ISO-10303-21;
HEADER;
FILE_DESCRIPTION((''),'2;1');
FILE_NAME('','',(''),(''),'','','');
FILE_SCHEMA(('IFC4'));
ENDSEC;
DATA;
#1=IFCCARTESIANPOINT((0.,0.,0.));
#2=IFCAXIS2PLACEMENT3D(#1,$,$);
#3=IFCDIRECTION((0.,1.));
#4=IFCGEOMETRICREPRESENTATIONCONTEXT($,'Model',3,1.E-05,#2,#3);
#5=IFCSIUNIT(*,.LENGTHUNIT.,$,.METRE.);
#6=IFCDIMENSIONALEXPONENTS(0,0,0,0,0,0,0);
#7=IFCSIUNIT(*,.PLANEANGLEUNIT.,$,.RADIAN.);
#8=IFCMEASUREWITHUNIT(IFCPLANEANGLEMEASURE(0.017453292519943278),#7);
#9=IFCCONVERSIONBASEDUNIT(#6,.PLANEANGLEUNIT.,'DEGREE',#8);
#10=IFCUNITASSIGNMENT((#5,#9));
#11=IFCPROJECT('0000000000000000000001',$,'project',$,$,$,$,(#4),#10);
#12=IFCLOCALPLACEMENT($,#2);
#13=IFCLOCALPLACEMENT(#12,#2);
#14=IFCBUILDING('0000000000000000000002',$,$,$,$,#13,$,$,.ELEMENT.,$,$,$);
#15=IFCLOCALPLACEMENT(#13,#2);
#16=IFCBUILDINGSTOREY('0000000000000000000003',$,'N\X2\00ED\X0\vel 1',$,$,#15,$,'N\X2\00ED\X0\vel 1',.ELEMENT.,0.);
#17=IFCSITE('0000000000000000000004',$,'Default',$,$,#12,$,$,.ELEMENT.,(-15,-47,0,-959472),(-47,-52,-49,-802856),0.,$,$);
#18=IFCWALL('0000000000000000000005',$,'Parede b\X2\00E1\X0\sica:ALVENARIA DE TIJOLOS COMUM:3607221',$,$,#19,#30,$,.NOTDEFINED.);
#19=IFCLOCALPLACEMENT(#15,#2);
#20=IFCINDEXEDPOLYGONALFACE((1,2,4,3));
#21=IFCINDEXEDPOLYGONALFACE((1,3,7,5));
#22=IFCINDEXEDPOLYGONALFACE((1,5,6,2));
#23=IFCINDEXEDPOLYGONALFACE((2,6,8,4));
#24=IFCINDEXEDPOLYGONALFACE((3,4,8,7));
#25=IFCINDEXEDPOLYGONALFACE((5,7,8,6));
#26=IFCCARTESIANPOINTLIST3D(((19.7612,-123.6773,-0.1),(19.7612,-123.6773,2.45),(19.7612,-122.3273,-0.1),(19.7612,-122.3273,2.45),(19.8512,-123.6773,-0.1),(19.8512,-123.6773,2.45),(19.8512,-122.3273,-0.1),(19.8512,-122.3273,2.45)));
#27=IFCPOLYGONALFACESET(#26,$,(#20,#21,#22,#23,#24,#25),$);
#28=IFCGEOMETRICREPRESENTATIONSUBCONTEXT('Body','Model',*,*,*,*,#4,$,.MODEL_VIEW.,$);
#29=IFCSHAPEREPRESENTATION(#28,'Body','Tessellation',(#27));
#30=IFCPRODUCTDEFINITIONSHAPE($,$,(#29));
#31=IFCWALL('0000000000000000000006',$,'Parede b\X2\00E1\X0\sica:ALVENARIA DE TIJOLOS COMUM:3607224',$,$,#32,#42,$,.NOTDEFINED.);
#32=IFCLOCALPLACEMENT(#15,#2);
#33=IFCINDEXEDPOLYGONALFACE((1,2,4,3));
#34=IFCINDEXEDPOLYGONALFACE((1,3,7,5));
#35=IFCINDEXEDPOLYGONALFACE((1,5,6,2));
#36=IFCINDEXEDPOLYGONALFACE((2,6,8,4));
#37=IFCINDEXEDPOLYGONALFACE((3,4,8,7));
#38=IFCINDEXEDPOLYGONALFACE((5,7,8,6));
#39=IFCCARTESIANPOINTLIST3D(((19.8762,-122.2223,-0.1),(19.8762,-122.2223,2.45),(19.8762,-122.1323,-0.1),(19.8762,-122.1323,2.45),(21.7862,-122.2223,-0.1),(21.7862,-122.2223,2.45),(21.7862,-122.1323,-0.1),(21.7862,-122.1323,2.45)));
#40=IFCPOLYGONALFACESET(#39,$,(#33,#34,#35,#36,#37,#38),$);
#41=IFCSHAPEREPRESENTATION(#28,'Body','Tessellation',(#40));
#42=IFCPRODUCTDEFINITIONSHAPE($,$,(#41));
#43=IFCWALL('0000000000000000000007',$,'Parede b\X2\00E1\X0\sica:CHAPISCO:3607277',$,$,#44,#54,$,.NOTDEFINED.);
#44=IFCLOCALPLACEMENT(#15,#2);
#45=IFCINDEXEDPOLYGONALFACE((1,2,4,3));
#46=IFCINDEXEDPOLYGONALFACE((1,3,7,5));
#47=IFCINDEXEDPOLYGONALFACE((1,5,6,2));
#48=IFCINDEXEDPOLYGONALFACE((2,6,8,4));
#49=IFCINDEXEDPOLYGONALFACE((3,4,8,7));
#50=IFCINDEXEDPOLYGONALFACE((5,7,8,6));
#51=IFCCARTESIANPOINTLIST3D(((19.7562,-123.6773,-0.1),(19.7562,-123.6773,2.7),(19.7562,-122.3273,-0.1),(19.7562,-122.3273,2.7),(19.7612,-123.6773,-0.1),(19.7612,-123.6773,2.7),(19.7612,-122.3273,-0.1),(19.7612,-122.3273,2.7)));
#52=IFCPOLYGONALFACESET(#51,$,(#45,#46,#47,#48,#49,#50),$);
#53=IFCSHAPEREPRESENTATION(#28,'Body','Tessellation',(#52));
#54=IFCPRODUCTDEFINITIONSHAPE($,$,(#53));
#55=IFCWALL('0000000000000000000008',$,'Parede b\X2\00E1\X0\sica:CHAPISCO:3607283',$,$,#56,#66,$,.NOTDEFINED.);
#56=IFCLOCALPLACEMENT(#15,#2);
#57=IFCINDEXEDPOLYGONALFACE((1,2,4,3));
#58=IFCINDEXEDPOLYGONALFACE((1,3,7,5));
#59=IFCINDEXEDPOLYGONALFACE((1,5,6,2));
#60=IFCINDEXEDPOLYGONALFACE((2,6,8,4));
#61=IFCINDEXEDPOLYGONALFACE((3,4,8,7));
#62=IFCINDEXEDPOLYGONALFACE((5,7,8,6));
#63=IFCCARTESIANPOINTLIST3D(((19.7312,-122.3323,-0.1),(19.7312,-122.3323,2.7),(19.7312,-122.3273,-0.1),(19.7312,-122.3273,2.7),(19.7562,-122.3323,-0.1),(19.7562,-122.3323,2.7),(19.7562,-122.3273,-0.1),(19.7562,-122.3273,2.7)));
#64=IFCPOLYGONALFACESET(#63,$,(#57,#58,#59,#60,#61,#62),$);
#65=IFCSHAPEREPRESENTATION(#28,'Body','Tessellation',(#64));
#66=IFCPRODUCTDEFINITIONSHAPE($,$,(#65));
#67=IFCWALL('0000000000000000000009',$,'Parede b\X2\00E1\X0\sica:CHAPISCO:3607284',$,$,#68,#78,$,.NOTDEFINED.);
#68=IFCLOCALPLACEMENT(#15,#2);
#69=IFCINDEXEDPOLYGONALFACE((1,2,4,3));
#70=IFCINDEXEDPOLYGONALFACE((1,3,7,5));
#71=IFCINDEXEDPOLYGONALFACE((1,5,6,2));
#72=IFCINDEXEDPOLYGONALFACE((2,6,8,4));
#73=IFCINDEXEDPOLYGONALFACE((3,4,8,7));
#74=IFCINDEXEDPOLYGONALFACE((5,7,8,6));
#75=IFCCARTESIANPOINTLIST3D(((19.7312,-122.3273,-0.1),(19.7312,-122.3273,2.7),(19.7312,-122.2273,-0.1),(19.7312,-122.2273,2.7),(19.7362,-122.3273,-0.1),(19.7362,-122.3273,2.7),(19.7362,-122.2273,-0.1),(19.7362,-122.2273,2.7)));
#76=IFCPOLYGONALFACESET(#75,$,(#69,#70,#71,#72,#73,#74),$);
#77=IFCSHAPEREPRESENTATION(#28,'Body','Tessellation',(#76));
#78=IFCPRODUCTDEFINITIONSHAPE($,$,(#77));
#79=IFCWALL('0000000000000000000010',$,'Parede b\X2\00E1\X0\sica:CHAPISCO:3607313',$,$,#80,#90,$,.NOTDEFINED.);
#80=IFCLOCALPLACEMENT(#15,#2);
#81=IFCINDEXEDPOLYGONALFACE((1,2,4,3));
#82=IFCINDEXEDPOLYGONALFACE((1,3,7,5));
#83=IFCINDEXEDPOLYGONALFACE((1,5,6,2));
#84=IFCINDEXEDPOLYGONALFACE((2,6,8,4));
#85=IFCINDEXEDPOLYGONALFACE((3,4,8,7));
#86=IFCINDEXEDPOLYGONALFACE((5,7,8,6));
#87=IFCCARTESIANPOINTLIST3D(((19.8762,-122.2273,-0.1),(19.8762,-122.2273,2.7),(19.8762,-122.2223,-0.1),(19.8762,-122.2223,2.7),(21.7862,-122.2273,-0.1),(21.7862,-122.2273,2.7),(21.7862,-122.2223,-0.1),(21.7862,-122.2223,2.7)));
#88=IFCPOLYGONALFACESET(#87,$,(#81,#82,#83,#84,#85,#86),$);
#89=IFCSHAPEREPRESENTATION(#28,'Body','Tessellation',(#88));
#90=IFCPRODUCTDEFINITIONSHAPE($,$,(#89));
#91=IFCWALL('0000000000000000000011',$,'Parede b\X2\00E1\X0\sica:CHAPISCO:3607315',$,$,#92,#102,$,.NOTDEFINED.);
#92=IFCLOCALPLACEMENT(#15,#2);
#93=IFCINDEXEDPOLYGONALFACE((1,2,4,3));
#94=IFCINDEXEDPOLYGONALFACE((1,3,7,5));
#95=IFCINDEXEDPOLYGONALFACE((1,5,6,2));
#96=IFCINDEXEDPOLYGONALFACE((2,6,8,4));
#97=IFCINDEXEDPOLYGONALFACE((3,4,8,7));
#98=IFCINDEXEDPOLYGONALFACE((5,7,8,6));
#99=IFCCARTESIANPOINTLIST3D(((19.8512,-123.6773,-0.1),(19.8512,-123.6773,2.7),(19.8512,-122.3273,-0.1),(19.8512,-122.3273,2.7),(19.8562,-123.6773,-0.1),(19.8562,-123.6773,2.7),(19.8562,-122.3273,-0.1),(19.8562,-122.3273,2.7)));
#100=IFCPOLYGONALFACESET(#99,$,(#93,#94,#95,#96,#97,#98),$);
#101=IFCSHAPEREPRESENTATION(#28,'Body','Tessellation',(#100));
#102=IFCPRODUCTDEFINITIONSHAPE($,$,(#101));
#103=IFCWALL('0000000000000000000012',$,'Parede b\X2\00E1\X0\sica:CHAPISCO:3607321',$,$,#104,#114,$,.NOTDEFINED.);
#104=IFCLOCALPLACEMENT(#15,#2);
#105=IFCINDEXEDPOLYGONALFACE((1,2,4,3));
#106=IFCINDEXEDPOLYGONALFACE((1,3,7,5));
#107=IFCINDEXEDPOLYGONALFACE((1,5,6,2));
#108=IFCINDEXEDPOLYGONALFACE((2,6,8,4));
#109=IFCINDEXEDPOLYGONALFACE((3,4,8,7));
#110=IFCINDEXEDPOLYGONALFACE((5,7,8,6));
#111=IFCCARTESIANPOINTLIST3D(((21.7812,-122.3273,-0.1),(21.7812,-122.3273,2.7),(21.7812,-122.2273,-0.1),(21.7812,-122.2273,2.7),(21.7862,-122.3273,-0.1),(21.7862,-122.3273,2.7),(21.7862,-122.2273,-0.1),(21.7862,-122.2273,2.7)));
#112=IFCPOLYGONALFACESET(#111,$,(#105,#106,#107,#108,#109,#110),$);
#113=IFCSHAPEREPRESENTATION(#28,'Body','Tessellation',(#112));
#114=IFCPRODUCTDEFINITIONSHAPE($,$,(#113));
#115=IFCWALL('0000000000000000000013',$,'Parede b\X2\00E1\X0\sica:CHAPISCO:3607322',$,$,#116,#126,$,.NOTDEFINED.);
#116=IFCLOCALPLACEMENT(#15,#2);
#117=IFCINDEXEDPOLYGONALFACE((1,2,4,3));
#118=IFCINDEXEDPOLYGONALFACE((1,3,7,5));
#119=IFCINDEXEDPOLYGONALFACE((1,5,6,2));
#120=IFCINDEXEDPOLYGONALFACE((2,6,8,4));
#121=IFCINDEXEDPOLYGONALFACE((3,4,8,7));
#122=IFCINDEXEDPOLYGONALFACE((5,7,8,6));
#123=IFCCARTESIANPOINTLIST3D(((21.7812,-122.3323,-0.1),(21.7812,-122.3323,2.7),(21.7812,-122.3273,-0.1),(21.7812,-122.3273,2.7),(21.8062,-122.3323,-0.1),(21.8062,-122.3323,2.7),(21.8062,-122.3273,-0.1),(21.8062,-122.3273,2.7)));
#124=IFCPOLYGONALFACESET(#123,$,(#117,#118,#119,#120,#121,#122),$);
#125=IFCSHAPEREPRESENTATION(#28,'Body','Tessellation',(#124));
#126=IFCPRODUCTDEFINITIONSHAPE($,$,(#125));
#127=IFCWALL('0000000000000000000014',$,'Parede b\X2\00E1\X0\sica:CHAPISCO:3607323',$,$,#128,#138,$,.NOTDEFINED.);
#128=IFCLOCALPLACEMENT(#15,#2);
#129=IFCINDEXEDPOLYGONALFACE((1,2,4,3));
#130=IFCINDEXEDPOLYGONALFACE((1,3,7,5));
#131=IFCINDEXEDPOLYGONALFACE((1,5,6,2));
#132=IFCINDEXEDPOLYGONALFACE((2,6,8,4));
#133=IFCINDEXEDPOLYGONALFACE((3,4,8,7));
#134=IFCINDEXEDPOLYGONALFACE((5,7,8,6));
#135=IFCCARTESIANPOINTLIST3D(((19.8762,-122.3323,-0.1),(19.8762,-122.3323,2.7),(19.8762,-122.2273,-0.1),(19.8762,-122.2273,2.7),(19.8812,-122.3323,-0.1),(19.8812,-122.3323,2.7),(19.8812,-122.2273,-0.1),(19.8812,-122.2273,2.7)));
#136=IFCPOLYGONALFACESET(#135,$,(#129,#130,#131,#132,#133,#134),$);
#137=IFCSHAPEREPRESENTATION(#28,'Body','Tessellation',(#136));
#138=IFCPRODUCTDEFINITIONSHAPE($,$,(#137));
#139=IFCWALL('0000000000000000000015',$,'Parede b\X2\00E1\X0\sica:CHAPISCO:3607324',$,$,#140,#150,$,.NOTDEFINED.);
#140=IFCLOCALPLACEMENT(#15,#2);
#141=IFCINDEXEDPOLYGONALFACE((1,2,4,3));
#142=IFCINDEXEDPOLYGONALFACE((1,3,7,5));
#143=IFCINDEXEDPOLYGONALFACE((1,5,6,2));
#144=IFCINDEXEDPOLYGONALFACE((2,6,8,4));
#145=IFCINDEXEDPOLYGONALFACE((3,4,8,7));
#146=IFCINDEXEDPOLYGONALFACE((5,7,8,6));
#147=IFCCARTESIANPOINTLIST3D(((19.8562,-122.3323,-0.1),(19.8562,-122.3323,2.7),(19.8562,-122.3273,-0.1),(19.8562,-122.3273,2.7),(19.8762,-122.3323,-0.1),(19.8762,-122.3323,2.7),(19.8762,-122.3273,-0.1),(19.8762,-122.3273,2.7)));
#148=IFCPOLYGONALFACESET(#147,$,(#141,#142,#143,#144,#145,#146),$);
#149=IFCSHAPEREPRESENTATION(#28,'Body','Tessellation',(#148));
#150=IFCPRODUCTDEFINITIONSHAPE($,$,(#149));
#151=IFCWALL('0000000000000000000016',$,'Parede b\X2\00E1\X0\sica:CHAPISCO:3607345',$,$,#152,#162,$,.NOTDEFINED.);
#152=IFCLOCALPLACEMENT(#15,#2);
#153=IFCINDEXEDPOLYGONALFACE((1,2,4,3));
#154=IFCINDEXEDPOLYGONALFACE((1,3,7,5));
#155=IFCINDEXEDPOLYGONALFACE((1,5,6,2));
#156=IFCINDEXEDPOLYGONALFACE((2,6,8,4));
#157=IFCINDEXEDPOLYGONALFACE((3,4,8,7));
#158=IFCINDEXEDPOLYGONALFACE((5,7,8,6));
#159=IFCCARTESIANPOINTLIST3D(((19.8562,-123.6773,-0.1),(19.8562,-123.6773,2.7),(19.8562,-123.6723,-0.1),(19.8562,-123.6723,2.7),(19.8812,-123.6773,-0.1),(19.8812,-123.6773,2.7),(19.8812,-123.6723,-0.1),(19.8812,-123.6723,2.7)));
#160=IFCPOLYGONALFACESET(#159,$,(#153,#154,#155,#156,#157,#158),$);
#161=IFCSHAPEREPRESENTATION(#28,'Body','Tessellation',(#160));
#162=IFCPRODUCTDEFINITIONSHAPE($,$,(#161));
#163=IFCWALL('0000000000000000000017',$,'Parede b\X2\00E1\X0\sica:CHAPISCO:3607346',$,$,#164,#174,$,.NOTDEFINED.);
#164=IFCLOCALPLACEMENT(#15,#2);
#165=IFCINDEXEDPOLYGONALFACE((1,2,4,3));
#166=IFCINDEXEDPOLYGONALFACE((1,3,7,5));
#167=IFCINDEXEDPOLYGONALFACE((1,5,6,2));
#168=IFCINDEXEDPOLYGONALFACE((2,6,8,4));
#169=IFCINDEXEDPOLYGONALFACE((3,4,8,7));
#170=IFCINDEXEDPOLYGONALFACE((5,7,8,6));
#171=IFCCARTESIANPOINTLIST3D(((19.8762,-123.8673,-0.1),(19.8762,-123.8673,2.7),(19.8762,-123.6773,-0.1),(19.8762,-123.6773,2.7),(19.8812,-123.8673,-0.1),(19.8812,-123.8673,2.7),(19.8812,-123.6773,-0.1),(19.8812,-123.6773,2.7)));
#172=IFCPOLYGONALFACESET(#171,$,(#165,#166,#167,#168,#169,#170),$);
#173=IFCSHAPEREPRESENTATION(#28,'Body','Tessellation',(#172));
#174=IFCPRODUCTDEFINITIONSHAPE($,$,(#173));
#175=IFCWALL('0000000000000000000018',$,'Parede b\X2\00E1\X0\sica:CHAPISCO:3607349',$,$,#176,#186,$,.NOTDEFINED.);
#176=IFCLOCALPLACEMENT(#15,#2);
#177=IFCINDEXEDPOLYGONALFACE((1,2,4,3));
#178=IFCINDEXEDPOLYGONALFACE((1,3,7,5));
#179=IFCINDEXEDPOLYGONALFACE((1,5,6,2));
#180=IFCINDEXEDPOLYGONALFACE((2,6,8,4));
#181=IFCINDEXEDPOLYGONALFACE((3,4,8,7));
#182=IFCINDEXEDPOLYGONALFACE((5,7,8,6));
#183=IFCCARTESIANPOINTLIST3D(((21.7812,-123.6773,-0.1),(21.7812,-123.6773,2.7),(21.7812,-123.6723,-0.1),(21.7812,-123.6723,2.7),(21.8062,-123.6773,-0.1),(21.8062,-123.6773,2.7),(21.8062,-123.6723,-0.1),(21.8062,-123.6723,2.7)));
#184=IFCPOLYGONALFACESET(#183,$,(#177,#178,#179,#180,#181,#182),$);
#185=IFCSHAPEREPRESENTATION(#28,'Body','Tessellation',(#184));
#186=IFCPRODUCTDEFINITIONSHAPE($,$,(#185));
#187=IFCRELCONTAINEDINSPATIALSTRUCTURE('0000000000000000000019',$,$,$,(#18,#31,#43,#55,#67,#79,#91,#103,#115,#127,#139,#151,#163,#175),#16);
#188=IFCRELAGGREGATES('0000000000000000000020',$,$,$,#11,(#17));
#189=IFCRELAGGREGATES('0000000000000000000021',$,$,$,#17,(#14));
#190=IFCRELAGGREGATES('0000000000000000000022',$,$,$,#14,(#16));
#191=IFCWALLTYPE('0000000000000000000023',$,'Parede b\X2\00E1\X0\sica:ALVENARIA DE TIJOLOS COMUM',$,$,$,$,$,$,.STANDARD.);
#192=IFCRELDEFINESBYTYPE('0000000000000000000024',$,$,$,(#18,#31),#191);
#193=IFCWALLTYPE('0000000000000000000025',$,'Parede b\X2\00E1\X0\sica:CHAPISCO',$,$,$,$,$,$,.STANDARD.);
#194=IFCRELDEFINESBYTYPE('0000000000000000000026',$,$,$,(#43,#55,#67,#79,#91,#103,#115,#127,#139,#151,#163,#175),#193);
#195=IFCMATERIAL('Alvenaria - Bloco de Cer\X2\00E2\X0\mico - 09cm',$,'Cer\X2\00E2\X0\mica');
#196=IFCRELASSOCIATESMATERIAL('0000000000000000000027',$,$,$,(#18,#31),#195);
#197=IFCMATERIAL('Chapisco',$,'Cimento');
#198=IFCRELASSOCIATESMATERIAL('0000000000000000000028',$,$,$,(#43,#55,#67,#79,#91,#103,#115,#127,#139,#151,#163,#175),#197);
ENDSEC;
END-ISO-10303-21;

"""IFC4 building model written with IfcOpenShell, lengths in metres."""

from ifc_helpers import new_model, entity, si_unit, converted_unit, direction, frame, origin, place, context, subcontext, project, spatial, indexed_curve, outline, extrude, material, type_object, element, save


model = new_model("IFC4")

# Units and contexts
model_context = context("Model", 3, precision=1e-05, world=origin(), true_north=direction((0.0, 1.0)))
body_context = subcontext(model_context, "Body", "Model", "MODEL_VIEW")
ifc_project = project(units=[si_unit("LENGTHUNIT", "METRE"), converted_unit("PLANEANGLEUNIT", "DEGREE", entity("IfcPlaneAngleMeasure", 0.017453292519943278), si_unit("PLANEANGLEUNIT", "RADIAN"), dimensions=[0, 0, 0, 0, 0, 0, 0])], contexts=[model_context])

# Site, building, storey
site_placement = place(None, origin())
site = spatial("IfcSite", under=ifc_project, at=site_placement, Name="Default", CompositionType="ELEMENT", RefLatitude=(-15, -47, 0, -959472), RefLongitude=(-47, -52, -49, -802856), RefElevation=0.0)
building_placement = place(site_placement, origin())
building = spatial("IfcBuilding", under=site, at=building_placement, CompositionType="ELEMENT")
storey_placement = place(building_placement, origin())
storey = spatial("IfcBuildingStorey", under=building, at=storey_placement, Name="Nível 1", LongName="Nível 1", CompositionType="ELEMENT", Elevation=0.0)

# Walls
ifc_material_1 = material(Name="Alvenaria - Bloco de Cerâmico - 09cm", Category="Cerâmica")
wall_type_1 = type_object("IfcWallType", Name="Parede básica:ALVENARIA DE TIJOLOS COMUM", PredefinedType="STANDARD")
wall_1_placement = place(storey_placement, frame((19.8062, -123.6773, -0.1), z_axis=(0.0, 0.0, 1.0), x_axis=(0.0, 1.0, 0.0)))
element("IfcWall", 1, at=wall_1_placement, inside=storey, type_object=wall_type_1, material=ifc_material_1, Name="Parede básica:ALVENARIA DE TIJOLOS COMUM:3607221", PredefinedType="NOTDEFINED", context=body_context, shape_type="SweptSolid", body=[
    extrude(outline(indexed_curve([(1.35, 0.045), (0.0, 0.045), (0.0, -0.045), (1.35, -0.045), (1.35, 0.045)], self_intersect=False)), origin(), (0.0, 0.0, 1.0), 2.55),
])
wall_2_placement = place(storey_placement, frame((21.7862, -122.1773, -0.1), z_axis=(0.0, 0.0, 1.0), x_axis=(-1.0, 0.0, 0.0)))
element("IfcWall", 2, at=wall_2_placement, inside=storey, type_object=wall_type_1, material=ifc_material_1, Name="Parede básica:ALVENARIA DE TIJOLOS COMUM:3607224", PredefinedType="NOTDEFINED", context=body_context, shape_type="SweptSolid", body=[
    extrude(outline(indexed_curve([(1.91, 0.045), (0.0, 0.045), (0.0, -0.045), (1.91, -0.045), (1.91, 0.045)], self_intersect=False)), origin(), (0.0, 0.0, 1.0), 2.55),
])
ifc_material_2 = material(Name="Chapisco", Category="Cimento")
wall_type_2 = type_object("IfcWallType", Name="Parede básica:CHAPISCO", PredefinedType="STANDARD")
wall_3_placement = place(storey_placement, frame((19.7587, -122.3273, -0.1), z_axis=(0.0, 0.0, 1.0), x_axis=(0.0, -1.0, 0.0)))
element("IfcWall", 3, at=wall_3_placement, inside=storey, type_object=wall_type_2, material=ifc_material_2, Name="Parede básica:CHAPISCO:3607277", PredefinedType="NOTDEFINED", context=body_context, shape_type="SweptSolid", body=[
    extrude(outline(indexed_curve([(1.35, 0.0025), (0.0, 0.0025), (0.0, -0.0025), (1.35, -0.0025), (1.35, 0.0025)], self_intersect=False)), origin(), (0.0, 0.0, 1.0), 2.8),
])
wall_4_placement = place(storey_placement, frame((19.7562, -122.3298, -0.1), z_axis=(0.0, 0.0, 1.0), x_axis=(-1.0, 0.0, 0.0)))
element("IfcWall", 4, at=wall_4_placement, inside=storey, type_object=wall_type_2, material=ifc_material_2, Name="Parede básica:CHAPISCO:3607283", PredefinedType="NOTDEFINED", context=body_context, shape_type="SweptSolid", body=[
    extrude(outline(indexed_curve([(0.025, 0.0025), (0.0, 0.0025), (0.0, -0.0025), (0.025, -0.0025), (0.025, 0.0025)], self_intersect=False)), origin(), (0.0, 0.0, 1.0), 2.8),
])
wall_5_placement = place(storey_placement, frame((19.7337, -122.3273, -0.1), z_axis=(0.0, 0.0, 1.0), x_axis=(0.0, 1.0, 0.0)))
element("IfcWall", 5, at=wall_5_placement, inside=storey, type_object=wall_type_2, material=ifc_material_2, Name="Parede básica:CHAPISCO:3607284", PredefinedType="NOTDEFINED", context=body_context, shape_type="SweptSolid", body=[
    extrude(outline(indexed_curve([(0.1, 0.0025), (0.0, 0.0025), (0.0, -0.0025), (0.1, -0.0025), (0.1, 0.0025)], self_intersect=False)), origin(), (0.0, 0.0, 1.0), 2.8),
])
wall_6_placement = place(storey_placement, frame((19.8762, -122.2248, -0.1)))
element("IfcWall", 6, at=wall_6_placement, inside=storey, type_object=wall_type_2, material=ifc_material_2, Name="Parede básica:CHAPISCO:3607313", PredefinedType="NOTDEFINED", context=body_context, shape_type="SweptSolid", body=[
    extrude(outline(indexed_curve([(1.91, 0.0025), (0.0, 0.0025), (0.0, -0.0025), (1.91, -0.0025), (1.91, 0.0025)], self_intersect=False)), origin(), (0.0, 0.0, 1.0), 2.8),
])
wall_7_placement = place(storey_placement, frame((19.8537, -123.6773, -0.1), z_axis=(0.0, 0.0, 1.0), x_axis=(0.0, 1.0, 0.0)))
element("IfcWall", 7, at=wall_7_placement, inside=storey, type_object=wall_type_2, material=ifc_material_2, Name="Parede básica:CHAPISCO:3607315", PredefinedType="NOTDEFINED", context=body_context, shape_type="SweptSolid", body=[
    extrude(outline(indexed_curve([(1.35, 0.0025), (0.0, 0.0025), (0.0, -0.0025), (1.35, -0.0025), (1.35, 0.0025)], self_intersect=False)), origin(), (0.0, 0.0, 1.0), 2.8),
])
wall_8_placement = place(storey_placement, frame((21.7837, -122.2273, -0.1), z_axis=(0.0, 0.0, 1.0), x_axis=(0.0, -1.0, 0.0)))
element("IfcWall", 8, at=wall_8_placement, inside=storey, type_object=wall_type_2, material=ifc_material_2, Name="Parede básica:CHAPISCO:3607321", PredefinedType="NOTDEFINED", context=body_context, shape_type="SweptSolid", body=[
    extrude(outline(indexed_curve([(0.1, 0.0025), (0.0, 0.0025), (0.0, -0.0025), (0.1, -0.0025), (0.1, 0.0025)], self_intersect=False)), origin(), (0.0, 0.0, 1.0), 2.8),
])
wall_9_placement = place(storey_placement, frame((21.7812, -122.3298, -0.1)))
element("IfcWall", 9, at=wall_9_placement, inside=storey, type_object=wall_type_2, material=ifc_material_2, Name="Parede básica:CHAPISCO:3607322", PredefinedType="NOTDEFINED", context=body_context, shape_type="SweptSolid", body=[
    extrude(outline(indexed_curve([(0.025, 0.0025), (0.0, 0.0025), (0.0, -0.0025), (0.025, -0.0025), (0.025, 0.0025)], self_intersect=False)), origin(), (0.0, 0.0, 1.0), 2.8),
])
wall_10_placement = place(storey_placement, frame((19.8787, -122.2273, -0.1), z_axis=(0.0, 0.0, 1.0), x_axis=(0.0, -1.0, 0.0)))
element("IfcWall", 10, at=wall_10_placement, inside=storey, type_object=wall_type_2, material=ifc_material_2, Name="Parede básica:CHAPISCO:3607323", PredefinedType="NOTDEFINED", context=body_context, shape_type="SweptSolid", body=[
    extrude(outline(indexed_curve([(0.105, 0.0025), (0.0, 0.0025), (0.0, -0.0025), (0.105, -0.0025), (0.105, 0.0025)], self_intersect=False)), origin(), (0.0, 0.0, 1.0), 2.8),
])
wall_11_placement = place(storey_placement, frame((19.8762, -122.3298, -0.1), z_axis=(0.0, 0.0, 1.0), x_axis=(-1.0, 0.0, 0.0)))
element("IfcWall", 11, at=wall_11_placement, inside=storey, type_object=wall_type_2, material=ifc_material_2, Name="Parede básica:CHAPISCO:3607324", PredefinedType="NOTDEFINED", context=body_context, shape_type="SweptSolid", body=[
    extrude(outline(indexed_curve([(0.02, 0.0025), (0.0, 0.0025), (0.0, -0.0025), (0.02, -0.0025), (0.02, 0.0025)], self_intersect=False)), origin(), (0.0, 0.0, 1.0), 2.8),
])
wall_12_placement = place(storey_placement, frame((19.8562, -123.6748, -0.1)))
element("IfcWall", 12, at=wall_12_placement, inside=storey, type_object=wall_type_2, material=ifc_material_2, Name="Parede básica:CHAPISCO:3607345", PredefinedType="NOTDEFINED", context=body_context, shape_type="SweptSolid", body=[
    extrude(outline(indexed_curve([(0.025, 0.0025), (0.0, 0.0025), (0.0, -0.0025), (0.025, -0.0025), (0.025, 0.0025)], self_intersect=False)), origin(), (0.0, 0.0, 1.0), 2.8),
])
wall_13_placement = place(storey_placement, frame((19.8787, -123.6773, -0.1), z_axis=(0.0, 0.0, 1.0), x_axis=(0.0, -1.0, 0.0)))
element("IfcWall", 13, at=wall_13_placement, inside=storey, type_object=wall_type_2, material=ifc_material_2, Name="Parede básica:CHAPISCO:3607346", PredefinedType="NOTDEFINED", context=body_context, shape_type="SweptSolid", body=[
    extrude(outline(indexed_curve([(0.19, 0.0025), (0.0, 0.0025), (0.0, -0.0025), (0.19, -0.0025), (0.19, 0.0025)], self_intersect=False)), origin(), (0.0, 0.0, 1.0), 2.8),
])
wall_14_placement = place(storey_placement, frame((21.8062, -123.6748, -0.1), z_axis=(0.0, 0.0, 1.0), x_axis=(-1.0, 0.0, 0.0)))
element("IfcWall", 14, at=wall_14_placement, inside=storey, type_object=wall_type_2, material=ifc_material_2, Name="Parede básica:CHAPISCO:3607349", PredefinedType="NOTDEFINED", context=body_context, shape_type="SweptSolid", body=[
    extrude(outline(indexed_curve([(0.025, 0.0025), (0.0, 0.0025), (0.0, -0.0025), (0.025, -0.0025), (0.025, 0.0025)], self_intersect=False)), origin(), (0.0, 0.0, 1.0), 2.8),
])

save(model, "model.ifc")
